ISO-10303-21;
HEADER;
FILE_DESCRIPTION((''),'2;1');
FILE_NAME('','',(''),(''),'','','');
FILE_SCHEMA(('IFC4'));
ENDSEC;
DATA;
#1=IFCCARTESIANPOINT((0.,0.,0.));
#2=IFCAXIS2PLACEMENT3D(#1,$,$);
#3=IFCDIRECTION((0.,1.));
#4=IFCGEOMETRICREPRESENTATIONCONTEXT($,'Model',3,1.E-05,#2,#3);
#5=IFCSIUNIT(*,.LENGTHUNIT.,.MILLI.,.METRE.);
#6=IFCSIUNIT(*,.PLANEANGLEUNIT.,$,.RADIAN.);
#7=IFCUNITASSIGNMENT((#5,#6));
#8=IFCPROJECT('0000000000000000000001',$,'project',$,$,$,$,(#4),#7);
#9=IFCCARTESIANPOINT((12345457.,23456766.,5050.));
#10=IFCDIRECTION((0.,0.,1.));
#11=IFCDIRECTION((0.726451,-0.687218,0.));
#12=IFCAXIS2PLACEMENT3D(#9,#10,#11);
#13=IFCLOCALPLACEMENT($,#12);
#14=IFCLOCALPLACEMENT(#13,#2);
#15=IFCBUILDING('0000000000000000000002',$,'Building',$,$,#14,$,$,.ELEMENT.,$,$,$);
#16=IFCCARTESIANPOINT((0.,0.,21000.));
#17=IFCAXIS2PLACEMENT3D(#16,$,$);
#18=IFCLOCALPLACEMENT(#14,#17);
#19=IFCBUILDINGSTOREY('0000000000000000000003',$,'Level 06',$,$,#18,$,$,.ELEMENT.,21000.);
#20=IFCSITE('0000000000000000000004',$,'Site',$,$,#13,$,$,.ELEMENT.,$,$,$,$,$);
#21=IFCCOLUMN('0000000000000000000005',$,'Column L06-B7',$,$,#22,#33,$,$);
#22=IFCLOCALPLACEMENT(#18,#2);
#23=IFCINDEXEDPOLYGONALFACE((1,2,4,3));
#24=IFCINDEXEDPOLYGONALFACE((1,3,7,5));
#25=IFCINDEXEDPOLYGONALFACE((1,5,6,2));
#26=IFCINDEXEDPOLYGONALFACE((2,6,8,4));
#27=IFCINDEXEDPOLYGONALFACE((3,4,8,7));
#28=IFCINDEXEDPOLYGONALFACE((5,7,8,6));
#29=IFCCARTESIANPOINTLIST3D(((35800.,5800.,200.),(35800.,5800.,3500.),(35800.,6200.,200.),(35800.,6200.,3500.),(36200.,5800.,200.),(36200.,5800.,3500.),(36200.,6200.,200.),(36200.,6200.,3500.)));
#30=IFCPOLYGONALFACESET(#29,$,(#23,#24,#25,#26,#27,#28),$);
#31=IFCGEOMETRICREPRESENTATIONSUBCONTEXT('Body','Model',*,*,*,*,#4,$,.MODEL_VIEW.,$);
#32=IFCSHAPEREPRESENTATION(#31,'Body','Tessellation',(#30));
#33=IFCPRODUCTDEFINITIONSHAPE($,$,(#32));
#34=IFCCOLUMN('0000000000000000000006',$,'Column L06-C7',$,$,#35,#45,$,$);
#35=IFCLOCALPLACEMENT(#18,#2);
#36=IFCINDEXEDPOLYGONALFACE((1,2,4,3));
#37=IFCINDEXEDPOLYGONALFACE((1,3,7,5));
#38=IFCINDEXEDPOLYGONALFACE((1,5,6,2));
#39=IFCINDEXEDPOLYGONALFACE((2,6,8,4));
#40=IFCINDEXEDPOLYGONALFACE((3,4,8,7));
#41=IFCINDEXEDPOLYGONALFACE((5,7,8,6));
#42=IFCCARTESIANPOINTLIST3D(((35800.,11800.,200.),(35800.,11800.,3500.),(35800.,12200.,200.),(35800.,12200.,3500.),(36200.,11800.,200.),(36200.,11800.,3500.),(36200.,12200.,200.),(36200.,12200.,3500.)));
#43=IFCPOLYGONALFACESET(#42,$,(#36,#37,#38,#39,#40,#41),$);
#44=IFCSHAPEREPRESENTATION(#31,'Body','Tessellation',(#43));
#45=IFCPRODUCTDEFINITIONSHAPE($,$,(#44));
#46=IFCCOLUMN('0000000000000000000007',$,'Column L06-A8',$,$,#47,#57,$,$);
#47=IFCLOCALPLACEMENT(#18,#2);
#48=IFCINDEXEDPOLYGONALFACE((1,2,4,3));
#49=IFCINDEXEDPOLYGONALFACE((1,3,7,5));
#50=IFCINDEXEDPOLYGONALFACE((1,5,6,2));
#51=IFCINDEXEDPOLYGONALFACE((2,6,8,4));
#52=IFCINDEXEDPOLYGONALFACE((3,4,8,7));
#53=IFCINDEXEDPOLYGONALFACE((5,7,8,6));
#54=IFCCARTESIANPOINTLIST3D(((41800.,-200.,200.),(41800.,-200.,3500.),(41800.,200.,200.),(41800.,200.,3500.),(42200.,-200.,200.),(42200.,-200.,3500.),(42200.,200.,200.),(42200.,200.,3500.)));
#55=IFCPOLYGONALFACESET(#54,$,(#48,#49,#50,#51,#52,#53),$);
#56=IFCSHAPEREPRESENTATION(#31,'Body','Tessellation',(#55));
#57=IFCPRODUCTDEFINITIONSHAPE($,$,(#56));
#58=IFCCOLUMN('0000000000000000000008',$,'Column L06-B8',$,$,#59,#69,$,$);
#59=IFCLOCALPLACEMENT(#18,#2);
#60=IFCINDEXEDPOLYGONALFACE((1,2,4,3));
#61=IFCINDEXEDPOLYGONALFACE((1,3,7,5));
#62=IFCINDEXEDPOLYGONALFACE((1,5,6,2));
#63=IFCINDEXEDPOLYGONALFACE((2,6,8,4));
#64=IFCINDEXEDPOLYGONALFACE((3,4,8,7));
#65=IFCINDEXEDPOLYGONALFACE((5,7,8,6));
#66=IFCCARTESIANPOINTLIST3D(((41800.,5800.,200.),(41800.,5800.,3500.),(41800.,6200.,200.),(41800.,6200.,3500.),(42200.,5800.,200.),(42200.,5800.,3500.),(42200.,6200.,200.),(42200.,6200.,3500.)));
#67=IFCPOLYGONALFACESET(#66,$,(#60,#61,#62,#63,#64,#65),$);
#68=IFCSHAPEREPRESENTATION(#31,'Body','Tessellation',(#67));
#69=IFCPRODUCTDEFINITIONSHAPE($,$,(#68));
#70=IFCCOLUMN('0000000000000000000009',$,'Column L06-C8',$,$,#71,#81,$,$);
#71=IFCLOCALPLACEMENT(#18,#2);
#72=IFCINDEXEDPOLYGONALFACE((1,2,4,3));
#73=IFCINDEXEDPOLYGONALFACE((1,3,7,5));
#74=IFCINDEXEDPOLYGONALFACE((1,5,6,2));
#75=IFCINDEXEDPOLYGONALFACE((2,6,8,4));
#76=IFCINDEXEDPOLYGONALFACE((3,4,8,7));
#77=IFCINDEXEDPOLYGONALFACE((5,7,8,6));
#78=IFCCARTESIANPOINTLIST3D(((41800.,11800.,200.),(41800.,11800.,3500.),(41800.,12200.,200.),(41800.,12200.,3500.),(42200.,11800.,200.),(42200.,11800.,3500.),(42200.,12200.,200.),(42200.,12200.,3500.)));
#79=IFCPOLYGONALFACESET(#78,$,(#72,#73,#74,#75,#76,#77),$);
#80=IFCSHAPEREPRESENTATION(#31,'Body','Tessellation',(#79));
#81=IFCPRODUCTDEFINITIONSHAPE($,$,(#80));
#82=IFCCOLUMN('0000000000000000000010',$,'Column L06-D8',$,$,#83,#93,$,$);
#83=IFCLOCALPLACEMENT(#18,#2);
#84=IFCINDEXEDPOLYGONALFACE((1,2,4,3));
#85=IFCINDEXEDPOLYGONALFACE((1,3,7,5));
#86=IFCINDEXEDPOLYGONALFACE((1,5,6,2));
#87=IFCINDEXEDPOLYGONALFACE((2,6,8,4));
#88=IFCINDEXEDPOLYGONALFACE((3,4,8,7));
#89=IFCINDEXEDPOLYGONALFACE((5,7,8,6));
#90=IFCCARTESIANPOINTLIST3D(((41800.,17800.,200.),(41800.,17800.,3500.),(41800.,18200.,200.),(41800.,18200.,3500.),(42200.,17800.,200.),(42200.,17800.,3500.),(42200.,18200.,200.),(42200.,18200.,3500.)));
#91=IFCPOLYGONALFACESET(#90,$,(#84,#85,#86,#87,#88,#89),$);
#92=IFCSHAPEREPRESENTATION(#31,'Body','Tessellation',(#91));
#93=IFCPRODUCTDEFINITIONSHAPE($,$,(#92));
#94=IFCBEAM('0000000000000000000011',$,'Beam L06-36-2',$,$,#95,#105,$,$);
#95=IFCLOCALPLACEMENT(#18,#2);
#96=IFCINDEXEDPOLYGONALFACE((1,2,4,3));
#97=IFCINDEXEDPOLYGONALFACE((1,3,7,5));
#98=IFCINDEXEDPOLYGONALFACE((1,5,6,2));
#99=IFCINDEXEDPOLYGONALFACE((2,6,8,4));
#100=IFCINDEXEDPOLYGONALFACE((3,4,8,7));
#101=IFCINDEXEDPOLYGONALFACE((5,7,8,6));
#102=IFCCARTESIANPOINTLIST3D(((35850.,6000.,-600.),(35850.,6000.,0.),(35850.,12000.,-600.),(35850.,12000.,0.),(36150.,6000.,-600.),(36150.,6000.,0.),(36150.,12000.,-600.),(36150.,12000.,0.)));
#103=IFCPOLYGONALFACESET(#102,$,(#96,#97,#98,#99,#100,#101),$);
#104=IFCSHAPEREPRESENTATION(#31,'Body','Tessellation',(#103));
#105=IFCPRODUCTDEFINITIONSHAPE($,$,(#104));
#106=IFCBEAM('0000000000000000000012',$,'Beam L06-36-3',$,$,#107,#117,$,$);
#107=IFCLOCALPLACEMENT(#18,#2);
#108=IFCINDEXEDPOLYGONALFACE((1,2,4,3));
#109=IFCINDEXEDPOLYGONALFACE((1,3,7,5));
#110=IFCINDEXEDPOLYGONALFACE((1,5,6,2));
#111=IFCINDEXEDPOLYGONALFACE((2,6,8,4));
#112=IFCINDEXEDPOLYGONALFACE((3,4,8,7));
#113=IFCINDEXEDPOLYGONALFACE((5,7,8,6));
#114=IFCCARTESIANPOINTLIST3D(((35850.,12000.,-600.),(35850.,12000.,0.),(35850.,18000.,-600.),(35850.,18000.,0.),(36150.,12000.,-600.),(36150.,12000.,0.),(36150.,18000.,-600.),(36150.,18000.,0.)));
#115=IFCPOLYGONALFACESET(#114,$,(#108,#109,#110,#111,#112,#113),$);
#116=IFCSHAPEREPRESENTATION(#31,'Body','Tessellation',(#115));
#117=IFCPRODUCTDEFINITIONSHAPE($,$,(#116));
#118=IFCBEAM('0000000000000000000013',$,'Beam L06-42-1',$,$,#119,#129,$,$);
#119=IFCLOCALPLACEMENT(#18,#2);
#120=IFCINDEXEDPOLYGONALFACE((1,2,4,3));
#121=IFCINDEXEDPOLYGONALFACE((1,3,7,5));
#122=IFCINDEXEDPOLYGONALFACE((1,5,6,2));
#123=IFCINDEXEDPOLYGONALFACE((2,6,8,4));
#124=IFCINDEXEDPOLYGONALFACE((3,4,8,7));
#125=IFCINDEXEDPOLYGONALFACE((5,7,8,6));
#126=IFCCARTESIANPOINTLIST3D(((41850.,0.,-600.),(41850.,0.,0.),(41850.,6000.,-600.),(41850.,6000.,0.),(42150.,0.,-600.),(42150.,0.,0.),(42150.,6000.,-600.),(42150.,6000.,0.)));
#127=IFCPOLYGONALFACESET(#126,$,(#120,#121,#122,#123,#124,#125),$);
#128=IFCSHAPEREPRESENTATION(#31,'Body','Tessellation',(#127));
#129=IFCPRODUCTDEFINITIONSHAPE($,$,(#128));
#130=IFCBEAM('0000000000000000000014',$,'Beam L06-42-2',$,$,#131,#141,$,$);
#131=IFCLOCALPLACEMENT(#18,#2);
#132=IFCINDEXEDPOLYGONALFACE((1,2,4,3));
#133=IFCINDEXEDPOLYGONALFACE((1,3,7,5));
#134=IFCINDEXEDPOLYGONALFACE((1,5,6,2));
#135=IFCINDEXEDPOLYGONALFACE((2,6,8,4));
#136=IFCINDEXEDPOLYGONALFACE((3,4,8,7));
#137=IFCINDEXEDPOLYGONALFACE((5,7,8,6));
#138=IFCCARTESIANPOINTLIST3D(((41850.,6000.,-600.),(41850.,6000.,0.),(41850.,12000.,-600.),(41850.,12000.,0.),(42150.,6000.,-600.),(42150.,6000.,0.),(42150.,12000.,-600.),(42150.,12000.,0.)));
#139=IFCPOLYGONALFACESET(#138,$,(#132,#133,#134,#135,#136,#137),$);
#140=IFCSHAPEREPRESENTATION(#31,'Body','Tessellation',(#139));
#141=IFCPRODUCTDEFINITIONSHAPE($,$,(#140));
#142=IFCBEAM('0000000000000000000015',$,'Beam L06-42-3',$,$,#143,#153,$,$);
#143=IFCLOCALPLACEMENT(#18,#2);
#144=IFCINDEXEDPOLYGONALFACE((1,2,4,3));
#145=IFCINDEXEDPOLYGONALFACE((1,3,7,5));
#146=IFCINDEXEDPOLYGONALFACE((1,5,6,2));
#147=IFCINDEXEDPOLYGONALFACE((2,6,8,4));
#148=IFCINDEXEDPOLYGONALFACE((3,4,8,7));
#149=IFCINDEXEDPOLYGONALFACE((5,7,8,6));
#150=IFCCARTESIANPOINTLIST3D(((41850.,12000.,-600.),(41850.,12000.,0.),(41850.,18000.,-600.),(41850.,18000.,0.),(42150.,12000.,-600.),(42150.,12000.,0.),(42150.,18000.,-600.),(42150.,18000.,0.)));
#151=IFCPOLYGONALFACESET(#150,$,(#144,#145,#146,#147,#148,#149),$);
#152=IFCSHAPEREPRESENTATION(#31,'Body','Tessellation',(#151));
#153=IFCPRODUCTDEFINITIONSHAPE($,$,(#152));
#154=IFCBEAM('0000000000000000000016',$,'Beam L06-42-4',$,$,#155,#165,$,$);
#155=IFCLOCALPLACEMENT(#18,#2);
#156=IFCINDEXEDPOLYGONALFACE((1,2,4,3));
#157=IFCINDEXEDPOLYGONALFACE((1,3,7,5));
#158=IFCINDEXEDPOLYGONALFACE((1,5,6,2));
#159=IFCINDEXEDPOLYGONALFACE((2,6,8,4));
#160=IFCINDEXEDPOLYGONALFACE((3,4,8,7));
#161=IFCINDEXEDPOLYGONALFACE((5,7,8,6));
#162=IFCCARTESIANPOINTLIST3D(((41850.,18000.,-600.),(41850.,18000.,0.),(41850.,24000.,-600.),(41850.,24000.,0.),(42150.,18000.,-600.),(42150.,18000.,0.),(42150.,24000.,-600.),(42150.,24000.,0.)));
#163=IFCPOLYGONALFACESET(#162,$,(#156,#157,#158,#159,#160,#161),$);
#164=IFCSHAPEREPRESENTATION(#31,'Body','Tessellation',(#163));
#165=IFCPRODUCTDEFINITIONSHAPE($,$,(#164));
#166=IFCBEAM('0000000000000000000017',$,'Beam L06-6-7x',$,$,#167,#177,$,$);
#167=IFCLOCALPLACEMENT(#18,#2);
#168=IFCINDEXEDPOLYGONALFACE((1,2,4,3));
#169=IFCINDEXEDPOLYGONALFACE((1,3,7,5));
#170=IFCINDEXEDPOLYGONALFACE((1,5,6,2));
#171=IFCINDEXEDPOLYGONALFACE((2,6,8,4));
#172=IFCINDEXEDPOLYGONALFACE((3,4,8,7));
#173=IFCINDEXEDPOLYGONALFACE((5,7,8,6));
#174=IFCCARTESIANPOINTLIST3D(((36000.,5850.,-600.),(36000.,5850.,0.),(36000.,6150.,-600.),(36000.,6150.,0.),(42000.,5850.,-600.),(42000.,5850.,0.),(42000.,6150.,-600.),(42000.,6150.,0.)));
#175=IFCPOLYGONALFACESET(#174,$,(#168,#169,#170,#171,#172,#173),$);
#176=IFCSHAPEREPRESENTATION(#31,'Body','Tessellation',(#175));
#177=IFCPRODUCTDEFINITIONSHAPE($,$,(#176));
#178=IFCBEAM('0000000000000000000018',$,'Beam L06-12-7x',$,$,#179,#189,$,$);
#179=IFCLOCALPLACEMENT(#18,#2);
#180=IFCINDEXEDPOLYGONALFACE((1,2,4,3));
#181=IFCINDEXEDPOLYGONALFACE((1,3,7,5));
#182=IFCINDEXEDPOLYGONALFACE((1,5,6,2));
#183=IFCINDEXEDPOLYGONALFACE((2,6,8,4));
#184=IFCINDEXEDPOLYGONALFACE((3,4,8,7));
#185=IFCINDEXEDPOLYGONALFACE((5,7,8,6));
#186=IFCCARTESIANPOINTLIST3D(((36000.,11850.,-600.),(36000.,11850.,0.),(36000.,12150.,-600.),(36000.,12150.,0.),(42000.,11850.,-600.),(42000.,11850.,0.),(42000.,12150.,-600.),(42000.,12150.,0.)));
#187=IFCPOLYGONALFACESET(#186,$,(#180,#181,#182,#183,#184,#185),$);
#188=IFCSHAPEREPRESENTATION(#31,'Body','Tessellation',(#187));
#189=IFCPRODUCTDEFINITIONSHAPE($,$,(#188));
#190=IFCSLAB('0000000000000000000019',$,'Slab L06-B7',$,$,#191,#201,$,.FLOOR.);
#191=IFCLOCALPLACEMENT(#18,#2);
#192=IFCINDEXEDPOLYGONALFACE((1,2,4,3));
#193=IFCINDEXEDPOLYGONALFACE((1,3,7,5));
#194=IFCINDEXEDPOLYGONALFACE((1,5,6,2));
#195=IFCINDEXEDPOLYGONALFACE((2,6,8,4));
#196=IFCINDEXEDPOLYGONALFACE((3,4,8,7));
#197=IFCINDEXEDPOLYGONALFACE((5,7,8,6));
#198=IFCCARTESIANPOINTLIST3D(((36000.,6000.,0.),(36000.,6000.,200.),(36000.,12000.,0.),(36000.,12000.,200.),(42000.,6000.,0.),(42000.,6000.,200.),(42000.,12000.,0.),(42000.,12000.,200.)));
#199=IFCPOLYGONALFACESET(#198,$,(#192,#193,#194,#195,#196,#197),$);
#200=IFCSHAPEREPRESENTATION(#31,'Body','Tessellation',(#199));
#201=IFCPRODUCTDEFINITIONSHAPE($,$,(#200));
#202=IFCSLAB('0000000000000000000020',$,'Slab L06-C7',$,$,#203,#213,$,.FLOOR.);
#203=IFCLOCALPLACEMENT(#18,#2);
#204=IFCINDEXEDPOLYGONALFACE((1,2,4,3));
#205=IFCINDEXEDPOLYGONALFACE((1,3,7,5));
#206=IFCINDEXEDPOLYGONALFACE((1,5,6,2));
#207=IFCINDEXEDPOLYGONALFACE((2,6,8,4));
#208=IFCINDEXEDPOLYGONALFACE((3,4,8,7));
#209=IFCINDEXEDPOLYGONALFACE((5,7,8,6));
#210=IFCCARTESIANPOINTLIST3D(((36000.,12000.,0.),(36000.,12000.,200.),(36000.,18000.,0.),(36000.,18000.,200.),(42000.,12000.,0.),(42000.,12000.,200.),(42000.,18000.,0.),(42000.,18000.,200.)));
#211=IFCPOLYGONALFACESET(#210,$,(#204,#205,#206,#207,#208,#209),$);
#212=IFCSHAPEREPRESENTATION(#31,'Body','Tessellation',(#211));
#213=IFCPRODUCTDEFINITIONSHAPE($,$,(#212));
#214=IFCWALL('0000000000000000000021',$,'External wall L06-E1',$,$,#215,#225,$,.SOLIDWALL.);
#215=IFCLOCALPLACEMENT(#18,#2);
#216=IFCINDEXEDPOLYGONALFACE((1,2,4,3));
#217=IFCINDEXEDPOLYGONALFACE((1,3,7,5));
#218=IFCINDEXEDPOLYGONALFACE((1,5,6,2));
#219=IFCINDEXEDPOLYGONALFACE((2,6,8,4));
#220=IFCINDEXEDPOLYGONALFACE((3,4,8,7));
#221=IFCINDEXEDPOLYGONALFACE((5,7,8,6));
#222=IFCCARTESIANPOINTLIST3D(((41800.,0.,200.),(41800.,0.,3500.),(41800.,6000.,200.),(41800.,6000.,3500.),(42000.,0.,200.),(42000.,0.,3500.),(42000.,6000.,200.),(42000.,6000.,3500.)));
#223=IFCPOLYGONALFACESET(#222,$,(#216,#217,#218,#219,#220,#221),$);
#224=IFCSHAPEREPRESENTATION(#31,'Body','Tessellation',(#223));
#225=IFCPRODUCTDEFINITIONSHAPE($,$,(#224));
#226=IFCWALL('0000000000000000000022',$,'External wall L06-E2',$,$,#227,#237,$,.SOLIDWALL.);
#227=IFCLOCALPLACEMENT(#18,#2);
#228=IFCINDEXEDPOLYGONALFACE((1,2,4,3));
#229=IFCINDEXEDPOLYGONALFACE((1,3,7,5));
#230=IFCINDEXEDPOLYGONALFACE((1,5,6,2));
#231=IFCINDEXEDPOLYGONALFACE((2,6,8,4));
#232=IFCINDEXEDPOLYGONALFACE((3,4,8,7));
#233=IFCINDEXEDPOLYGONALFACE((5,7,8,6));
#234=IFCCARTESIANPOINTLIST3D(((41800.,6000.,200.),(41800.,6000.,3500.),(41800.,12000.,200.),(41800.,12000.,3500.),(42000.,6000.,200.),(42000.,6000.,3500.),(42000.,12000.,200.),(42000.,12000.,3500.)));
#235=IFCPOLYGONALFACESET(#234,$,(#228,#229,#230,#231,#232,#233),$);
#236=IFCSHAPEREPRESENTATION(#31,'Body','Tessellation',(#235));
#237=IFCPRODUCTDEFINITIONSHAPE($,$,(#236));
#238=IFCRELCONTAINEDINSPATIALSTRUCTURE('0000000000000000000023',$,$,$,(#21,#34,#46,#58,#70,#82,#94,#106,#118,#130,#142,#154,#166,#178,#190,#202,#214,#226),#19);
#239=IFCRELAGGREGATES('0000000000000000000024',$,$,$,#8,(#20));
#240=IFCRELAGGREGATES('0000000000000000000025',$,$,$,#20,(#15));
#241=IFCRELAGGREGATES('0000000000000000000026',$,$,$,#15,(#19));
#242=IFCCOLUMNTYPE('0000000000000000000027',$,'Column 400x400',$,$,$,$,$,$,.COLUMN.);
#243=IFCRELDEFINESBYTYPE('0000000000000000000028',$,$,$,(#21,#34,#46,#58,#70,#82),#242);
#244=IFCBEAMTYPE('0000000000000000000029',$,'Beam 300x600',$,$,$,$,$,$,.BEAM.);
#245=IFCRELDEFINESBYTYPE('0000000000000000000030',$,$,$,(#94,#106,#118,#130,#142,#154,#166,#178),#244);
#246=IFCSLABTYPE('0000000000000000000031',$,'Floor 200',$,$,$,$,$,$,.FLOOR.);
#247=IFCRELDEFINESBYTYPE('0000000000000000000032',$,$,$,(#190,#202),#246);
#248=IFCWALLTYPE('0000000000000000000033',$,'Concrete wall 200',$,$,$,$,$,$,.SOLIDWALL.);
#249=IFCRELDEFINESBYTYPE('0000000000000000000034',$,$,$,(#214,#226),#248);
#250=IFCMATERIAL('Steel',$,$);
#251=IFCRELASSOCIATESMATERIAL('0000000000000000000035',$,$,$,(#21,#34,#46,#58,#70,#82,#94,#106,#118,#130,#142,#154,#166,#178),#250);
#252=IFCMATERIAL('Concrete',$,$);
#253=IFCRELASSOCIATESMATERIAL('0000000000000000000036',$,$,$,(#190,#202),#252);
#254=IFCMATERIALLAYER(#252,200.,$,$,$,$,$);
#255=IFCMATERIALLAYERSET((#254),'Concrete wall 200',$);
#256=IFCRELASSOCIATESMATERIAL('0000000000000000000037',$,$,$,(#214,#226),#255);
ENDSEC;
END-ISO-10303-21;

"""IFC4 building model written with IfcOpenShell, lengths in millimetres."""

from ifc_helpers import new_model, si_unit, direction, frame, origin, place, context, subcontext, project, spatial, rectangle, extrude, material, layer, layer_set, layer_usage, type_object, element, save


model = new_model("IFC4")

# Units and contexts
model_context = context("Model", 3, precision=1e-05, world=origin(), true_north=direction((0.0, 1.0)))
body_context = subcontext(model_context, "Body", "Model", "MODEL_VIEW")
ifc_project = project(units=[si_unit("LENGTHUNIT", "METRE", prefix="MILLI"), si_unit("PLANEANGLEUNIT", "RADIAN")], contexts=[model_context])

# Site, building, storey
site_placement = place(None, frame((12345457.0, 23456766.0, 5050.0), z_axis=(0.0, 0.0, 1.0), x_axis=(0.726451, -0.687218, 0.0)))
site = spatial("IfcSite", under=ifc_project, at=site_placement, Name="Site", CompositionType="ELEMENT")
building_placement = place(site_placement, origin())
building = spatial("IfcBuilding", under=site, at=building_placement, Name="Building", CompositionType="ELEMENT")
storey_placement = place(building_placement, frame((0.0, 0.0, 21000.0)))
storey = spatial("IfcBuildingStorey", under=building, at=storey_placement, Name="Level 06", CompositionType="ELEMENT", Elevation=21000.0)

# Columns
ifc_material_1 = material(Name="Steel")
column_type = type_object("IfcColumnType", Name="Column 400x400", PredefinedType="COLUMN")
for number, where, name in (
    (1, (35800.0, 5800.0, 200.0), "Column L06-B7"),
    (2, (35800.0, 11800.0, 200.0), "Column L06-C7"),
    (3, (41800.0, -200.0, 200.0), "Column L06-A8"),
    (4, (41800.0, 5800.0, 200.0), "Column L06-B8"),
    (5, (41800.0, 11800.0, 200.0), "Column L06-C8"),
    (6, (41800.0, 17800.0, 200.0), "Column L06-D8"),
):
    element("IfcColumn", number, at=place(storey_placement, frame(where)), inside=storey, type_object=column_type, material=ifc_material_1, Name=name, context=body_context, shape_type="SweptSolid", body=[
        extrude(rectangle(XDim=400.0, YDim=400.0), frame((200.0, 200.0, 0.0)), (0.0, 0.0, 1.0), 3300.0),
    ])

# Beams
beam_type = type_object("IfcBeamType", Name="Beam 300x600", PredefinedType="BEAM")
for number, where, name in (
    (7, (35850.0, 6000.0, -600.0), "Beam L06-36-2"),
    (8, (35850.0, 12000.0, -600.0), "Beam L06-36-3"),
    (9, (41850.0, 0.0, -600.0), "Beam L06-42-1"),
    (10, (41850.0, 6000.0, -600.0), "Beam L06-42-2"),
    (11, (41850.0, 12000.0, -600.0), "Beam L06-42-3"),
    (12, (41850.0, 18000.0, -600.0), "Beam L06-42-4"),
):
    element("IfcBeam", number, at=place(storey_placement, frame(where)), inside=storey, type_object=beam_type, material=ifc_material_1, Name=name, context=body_context, shape_type="SweptSolid", body=[
        extrude(rectangle(XDim=300.0, YDim=6000.0), frame((150.0, 3000.0, 0.0)), (0.0, 0.0, 1.0), 600.0),
    ])
for number, where, name in (
    (13, (36000.0, 5850.0, -600.0), "Beam L06-6-7x"),
    (14, (36000.0, 11850.0, -600.0), "Beam L06-12-7x"),
):
    element("IfcBeam", number, at=place(storey_placement, frame(where)), inside=storey, type_object=beam_type, material=ifc_material_1, Name=name, context=body_context, shape_type="SweptSolid", body=[
        extrude(rectangle(XDim=6000.0, YDim=300.0), frame((3000.0, 150.0, 0.0)), (0.0, 0.0, 1.0), 600.0),
    ])

# Slabs
ifc_material_2 = material(Name="Concrete")
slab_type = type_object("IfcSlabType", Name="Floor 200", PredefinedType="FLOOR")
for number, where, name in (
    (15, (36000.0, 6000.0, 0.0), "Slab L06-B7"),
    (16, (36000.0, 12000.0, 0.0), "Slab L06-C7"),
):
    element("IfcSlab", number, at=place(storey_placement, frame(where)), inside=storey, type_object=slab_type, material=ifc_material_2, Name=name, PredefinedType="FLOOR", context=body_context, shape_type="SweptSolid", body=[
        extrude(rectangle(XDim=6000.0, YDim=6000.0), frame((3000.0, 3000.0, 0.0)), (0.0, 0.0, 1.0), 200.0),
    ])

# Walls
ifc_layer_1 = layer(ifc_material_2, 200.0)
ifc_layer_set_1 = layer_set([ifc_layer_1], Name="Concrete wall 200")
ifc_layer_usage_1 = layer_usage(ifc_layer_set_1, "AXIS2", "POSITIVE", 0.0)
wall_type_1 = type_object("IfcWallType", Name="Concrete wall 200", PredefinedType="SOLIDWALL")
for number, where, name in (
    (17, (41800.0, 0.0, 200.0), "External wall L06-E1"),
    (18, (41800.0, 6000.0, 200.0), "External wall L06-E2"),
):
    element("IfcWall", number, at=place(storey_placement, frame(where)), inside=storey, type_object=wall_type_1, material=ifc_layer_usage_1, Name=name, PredefinedType="SOLIDWALL", context=body_context, shape_type="SweptSolid", body=[
        extrude(rectangle(XDim=200.0, YDim=6000.0), frame((100.0, 3000.0, 0.0)), (0.0, 0.0, 1.0), 3300.0),
    ])

save(model, "model.ifc")
